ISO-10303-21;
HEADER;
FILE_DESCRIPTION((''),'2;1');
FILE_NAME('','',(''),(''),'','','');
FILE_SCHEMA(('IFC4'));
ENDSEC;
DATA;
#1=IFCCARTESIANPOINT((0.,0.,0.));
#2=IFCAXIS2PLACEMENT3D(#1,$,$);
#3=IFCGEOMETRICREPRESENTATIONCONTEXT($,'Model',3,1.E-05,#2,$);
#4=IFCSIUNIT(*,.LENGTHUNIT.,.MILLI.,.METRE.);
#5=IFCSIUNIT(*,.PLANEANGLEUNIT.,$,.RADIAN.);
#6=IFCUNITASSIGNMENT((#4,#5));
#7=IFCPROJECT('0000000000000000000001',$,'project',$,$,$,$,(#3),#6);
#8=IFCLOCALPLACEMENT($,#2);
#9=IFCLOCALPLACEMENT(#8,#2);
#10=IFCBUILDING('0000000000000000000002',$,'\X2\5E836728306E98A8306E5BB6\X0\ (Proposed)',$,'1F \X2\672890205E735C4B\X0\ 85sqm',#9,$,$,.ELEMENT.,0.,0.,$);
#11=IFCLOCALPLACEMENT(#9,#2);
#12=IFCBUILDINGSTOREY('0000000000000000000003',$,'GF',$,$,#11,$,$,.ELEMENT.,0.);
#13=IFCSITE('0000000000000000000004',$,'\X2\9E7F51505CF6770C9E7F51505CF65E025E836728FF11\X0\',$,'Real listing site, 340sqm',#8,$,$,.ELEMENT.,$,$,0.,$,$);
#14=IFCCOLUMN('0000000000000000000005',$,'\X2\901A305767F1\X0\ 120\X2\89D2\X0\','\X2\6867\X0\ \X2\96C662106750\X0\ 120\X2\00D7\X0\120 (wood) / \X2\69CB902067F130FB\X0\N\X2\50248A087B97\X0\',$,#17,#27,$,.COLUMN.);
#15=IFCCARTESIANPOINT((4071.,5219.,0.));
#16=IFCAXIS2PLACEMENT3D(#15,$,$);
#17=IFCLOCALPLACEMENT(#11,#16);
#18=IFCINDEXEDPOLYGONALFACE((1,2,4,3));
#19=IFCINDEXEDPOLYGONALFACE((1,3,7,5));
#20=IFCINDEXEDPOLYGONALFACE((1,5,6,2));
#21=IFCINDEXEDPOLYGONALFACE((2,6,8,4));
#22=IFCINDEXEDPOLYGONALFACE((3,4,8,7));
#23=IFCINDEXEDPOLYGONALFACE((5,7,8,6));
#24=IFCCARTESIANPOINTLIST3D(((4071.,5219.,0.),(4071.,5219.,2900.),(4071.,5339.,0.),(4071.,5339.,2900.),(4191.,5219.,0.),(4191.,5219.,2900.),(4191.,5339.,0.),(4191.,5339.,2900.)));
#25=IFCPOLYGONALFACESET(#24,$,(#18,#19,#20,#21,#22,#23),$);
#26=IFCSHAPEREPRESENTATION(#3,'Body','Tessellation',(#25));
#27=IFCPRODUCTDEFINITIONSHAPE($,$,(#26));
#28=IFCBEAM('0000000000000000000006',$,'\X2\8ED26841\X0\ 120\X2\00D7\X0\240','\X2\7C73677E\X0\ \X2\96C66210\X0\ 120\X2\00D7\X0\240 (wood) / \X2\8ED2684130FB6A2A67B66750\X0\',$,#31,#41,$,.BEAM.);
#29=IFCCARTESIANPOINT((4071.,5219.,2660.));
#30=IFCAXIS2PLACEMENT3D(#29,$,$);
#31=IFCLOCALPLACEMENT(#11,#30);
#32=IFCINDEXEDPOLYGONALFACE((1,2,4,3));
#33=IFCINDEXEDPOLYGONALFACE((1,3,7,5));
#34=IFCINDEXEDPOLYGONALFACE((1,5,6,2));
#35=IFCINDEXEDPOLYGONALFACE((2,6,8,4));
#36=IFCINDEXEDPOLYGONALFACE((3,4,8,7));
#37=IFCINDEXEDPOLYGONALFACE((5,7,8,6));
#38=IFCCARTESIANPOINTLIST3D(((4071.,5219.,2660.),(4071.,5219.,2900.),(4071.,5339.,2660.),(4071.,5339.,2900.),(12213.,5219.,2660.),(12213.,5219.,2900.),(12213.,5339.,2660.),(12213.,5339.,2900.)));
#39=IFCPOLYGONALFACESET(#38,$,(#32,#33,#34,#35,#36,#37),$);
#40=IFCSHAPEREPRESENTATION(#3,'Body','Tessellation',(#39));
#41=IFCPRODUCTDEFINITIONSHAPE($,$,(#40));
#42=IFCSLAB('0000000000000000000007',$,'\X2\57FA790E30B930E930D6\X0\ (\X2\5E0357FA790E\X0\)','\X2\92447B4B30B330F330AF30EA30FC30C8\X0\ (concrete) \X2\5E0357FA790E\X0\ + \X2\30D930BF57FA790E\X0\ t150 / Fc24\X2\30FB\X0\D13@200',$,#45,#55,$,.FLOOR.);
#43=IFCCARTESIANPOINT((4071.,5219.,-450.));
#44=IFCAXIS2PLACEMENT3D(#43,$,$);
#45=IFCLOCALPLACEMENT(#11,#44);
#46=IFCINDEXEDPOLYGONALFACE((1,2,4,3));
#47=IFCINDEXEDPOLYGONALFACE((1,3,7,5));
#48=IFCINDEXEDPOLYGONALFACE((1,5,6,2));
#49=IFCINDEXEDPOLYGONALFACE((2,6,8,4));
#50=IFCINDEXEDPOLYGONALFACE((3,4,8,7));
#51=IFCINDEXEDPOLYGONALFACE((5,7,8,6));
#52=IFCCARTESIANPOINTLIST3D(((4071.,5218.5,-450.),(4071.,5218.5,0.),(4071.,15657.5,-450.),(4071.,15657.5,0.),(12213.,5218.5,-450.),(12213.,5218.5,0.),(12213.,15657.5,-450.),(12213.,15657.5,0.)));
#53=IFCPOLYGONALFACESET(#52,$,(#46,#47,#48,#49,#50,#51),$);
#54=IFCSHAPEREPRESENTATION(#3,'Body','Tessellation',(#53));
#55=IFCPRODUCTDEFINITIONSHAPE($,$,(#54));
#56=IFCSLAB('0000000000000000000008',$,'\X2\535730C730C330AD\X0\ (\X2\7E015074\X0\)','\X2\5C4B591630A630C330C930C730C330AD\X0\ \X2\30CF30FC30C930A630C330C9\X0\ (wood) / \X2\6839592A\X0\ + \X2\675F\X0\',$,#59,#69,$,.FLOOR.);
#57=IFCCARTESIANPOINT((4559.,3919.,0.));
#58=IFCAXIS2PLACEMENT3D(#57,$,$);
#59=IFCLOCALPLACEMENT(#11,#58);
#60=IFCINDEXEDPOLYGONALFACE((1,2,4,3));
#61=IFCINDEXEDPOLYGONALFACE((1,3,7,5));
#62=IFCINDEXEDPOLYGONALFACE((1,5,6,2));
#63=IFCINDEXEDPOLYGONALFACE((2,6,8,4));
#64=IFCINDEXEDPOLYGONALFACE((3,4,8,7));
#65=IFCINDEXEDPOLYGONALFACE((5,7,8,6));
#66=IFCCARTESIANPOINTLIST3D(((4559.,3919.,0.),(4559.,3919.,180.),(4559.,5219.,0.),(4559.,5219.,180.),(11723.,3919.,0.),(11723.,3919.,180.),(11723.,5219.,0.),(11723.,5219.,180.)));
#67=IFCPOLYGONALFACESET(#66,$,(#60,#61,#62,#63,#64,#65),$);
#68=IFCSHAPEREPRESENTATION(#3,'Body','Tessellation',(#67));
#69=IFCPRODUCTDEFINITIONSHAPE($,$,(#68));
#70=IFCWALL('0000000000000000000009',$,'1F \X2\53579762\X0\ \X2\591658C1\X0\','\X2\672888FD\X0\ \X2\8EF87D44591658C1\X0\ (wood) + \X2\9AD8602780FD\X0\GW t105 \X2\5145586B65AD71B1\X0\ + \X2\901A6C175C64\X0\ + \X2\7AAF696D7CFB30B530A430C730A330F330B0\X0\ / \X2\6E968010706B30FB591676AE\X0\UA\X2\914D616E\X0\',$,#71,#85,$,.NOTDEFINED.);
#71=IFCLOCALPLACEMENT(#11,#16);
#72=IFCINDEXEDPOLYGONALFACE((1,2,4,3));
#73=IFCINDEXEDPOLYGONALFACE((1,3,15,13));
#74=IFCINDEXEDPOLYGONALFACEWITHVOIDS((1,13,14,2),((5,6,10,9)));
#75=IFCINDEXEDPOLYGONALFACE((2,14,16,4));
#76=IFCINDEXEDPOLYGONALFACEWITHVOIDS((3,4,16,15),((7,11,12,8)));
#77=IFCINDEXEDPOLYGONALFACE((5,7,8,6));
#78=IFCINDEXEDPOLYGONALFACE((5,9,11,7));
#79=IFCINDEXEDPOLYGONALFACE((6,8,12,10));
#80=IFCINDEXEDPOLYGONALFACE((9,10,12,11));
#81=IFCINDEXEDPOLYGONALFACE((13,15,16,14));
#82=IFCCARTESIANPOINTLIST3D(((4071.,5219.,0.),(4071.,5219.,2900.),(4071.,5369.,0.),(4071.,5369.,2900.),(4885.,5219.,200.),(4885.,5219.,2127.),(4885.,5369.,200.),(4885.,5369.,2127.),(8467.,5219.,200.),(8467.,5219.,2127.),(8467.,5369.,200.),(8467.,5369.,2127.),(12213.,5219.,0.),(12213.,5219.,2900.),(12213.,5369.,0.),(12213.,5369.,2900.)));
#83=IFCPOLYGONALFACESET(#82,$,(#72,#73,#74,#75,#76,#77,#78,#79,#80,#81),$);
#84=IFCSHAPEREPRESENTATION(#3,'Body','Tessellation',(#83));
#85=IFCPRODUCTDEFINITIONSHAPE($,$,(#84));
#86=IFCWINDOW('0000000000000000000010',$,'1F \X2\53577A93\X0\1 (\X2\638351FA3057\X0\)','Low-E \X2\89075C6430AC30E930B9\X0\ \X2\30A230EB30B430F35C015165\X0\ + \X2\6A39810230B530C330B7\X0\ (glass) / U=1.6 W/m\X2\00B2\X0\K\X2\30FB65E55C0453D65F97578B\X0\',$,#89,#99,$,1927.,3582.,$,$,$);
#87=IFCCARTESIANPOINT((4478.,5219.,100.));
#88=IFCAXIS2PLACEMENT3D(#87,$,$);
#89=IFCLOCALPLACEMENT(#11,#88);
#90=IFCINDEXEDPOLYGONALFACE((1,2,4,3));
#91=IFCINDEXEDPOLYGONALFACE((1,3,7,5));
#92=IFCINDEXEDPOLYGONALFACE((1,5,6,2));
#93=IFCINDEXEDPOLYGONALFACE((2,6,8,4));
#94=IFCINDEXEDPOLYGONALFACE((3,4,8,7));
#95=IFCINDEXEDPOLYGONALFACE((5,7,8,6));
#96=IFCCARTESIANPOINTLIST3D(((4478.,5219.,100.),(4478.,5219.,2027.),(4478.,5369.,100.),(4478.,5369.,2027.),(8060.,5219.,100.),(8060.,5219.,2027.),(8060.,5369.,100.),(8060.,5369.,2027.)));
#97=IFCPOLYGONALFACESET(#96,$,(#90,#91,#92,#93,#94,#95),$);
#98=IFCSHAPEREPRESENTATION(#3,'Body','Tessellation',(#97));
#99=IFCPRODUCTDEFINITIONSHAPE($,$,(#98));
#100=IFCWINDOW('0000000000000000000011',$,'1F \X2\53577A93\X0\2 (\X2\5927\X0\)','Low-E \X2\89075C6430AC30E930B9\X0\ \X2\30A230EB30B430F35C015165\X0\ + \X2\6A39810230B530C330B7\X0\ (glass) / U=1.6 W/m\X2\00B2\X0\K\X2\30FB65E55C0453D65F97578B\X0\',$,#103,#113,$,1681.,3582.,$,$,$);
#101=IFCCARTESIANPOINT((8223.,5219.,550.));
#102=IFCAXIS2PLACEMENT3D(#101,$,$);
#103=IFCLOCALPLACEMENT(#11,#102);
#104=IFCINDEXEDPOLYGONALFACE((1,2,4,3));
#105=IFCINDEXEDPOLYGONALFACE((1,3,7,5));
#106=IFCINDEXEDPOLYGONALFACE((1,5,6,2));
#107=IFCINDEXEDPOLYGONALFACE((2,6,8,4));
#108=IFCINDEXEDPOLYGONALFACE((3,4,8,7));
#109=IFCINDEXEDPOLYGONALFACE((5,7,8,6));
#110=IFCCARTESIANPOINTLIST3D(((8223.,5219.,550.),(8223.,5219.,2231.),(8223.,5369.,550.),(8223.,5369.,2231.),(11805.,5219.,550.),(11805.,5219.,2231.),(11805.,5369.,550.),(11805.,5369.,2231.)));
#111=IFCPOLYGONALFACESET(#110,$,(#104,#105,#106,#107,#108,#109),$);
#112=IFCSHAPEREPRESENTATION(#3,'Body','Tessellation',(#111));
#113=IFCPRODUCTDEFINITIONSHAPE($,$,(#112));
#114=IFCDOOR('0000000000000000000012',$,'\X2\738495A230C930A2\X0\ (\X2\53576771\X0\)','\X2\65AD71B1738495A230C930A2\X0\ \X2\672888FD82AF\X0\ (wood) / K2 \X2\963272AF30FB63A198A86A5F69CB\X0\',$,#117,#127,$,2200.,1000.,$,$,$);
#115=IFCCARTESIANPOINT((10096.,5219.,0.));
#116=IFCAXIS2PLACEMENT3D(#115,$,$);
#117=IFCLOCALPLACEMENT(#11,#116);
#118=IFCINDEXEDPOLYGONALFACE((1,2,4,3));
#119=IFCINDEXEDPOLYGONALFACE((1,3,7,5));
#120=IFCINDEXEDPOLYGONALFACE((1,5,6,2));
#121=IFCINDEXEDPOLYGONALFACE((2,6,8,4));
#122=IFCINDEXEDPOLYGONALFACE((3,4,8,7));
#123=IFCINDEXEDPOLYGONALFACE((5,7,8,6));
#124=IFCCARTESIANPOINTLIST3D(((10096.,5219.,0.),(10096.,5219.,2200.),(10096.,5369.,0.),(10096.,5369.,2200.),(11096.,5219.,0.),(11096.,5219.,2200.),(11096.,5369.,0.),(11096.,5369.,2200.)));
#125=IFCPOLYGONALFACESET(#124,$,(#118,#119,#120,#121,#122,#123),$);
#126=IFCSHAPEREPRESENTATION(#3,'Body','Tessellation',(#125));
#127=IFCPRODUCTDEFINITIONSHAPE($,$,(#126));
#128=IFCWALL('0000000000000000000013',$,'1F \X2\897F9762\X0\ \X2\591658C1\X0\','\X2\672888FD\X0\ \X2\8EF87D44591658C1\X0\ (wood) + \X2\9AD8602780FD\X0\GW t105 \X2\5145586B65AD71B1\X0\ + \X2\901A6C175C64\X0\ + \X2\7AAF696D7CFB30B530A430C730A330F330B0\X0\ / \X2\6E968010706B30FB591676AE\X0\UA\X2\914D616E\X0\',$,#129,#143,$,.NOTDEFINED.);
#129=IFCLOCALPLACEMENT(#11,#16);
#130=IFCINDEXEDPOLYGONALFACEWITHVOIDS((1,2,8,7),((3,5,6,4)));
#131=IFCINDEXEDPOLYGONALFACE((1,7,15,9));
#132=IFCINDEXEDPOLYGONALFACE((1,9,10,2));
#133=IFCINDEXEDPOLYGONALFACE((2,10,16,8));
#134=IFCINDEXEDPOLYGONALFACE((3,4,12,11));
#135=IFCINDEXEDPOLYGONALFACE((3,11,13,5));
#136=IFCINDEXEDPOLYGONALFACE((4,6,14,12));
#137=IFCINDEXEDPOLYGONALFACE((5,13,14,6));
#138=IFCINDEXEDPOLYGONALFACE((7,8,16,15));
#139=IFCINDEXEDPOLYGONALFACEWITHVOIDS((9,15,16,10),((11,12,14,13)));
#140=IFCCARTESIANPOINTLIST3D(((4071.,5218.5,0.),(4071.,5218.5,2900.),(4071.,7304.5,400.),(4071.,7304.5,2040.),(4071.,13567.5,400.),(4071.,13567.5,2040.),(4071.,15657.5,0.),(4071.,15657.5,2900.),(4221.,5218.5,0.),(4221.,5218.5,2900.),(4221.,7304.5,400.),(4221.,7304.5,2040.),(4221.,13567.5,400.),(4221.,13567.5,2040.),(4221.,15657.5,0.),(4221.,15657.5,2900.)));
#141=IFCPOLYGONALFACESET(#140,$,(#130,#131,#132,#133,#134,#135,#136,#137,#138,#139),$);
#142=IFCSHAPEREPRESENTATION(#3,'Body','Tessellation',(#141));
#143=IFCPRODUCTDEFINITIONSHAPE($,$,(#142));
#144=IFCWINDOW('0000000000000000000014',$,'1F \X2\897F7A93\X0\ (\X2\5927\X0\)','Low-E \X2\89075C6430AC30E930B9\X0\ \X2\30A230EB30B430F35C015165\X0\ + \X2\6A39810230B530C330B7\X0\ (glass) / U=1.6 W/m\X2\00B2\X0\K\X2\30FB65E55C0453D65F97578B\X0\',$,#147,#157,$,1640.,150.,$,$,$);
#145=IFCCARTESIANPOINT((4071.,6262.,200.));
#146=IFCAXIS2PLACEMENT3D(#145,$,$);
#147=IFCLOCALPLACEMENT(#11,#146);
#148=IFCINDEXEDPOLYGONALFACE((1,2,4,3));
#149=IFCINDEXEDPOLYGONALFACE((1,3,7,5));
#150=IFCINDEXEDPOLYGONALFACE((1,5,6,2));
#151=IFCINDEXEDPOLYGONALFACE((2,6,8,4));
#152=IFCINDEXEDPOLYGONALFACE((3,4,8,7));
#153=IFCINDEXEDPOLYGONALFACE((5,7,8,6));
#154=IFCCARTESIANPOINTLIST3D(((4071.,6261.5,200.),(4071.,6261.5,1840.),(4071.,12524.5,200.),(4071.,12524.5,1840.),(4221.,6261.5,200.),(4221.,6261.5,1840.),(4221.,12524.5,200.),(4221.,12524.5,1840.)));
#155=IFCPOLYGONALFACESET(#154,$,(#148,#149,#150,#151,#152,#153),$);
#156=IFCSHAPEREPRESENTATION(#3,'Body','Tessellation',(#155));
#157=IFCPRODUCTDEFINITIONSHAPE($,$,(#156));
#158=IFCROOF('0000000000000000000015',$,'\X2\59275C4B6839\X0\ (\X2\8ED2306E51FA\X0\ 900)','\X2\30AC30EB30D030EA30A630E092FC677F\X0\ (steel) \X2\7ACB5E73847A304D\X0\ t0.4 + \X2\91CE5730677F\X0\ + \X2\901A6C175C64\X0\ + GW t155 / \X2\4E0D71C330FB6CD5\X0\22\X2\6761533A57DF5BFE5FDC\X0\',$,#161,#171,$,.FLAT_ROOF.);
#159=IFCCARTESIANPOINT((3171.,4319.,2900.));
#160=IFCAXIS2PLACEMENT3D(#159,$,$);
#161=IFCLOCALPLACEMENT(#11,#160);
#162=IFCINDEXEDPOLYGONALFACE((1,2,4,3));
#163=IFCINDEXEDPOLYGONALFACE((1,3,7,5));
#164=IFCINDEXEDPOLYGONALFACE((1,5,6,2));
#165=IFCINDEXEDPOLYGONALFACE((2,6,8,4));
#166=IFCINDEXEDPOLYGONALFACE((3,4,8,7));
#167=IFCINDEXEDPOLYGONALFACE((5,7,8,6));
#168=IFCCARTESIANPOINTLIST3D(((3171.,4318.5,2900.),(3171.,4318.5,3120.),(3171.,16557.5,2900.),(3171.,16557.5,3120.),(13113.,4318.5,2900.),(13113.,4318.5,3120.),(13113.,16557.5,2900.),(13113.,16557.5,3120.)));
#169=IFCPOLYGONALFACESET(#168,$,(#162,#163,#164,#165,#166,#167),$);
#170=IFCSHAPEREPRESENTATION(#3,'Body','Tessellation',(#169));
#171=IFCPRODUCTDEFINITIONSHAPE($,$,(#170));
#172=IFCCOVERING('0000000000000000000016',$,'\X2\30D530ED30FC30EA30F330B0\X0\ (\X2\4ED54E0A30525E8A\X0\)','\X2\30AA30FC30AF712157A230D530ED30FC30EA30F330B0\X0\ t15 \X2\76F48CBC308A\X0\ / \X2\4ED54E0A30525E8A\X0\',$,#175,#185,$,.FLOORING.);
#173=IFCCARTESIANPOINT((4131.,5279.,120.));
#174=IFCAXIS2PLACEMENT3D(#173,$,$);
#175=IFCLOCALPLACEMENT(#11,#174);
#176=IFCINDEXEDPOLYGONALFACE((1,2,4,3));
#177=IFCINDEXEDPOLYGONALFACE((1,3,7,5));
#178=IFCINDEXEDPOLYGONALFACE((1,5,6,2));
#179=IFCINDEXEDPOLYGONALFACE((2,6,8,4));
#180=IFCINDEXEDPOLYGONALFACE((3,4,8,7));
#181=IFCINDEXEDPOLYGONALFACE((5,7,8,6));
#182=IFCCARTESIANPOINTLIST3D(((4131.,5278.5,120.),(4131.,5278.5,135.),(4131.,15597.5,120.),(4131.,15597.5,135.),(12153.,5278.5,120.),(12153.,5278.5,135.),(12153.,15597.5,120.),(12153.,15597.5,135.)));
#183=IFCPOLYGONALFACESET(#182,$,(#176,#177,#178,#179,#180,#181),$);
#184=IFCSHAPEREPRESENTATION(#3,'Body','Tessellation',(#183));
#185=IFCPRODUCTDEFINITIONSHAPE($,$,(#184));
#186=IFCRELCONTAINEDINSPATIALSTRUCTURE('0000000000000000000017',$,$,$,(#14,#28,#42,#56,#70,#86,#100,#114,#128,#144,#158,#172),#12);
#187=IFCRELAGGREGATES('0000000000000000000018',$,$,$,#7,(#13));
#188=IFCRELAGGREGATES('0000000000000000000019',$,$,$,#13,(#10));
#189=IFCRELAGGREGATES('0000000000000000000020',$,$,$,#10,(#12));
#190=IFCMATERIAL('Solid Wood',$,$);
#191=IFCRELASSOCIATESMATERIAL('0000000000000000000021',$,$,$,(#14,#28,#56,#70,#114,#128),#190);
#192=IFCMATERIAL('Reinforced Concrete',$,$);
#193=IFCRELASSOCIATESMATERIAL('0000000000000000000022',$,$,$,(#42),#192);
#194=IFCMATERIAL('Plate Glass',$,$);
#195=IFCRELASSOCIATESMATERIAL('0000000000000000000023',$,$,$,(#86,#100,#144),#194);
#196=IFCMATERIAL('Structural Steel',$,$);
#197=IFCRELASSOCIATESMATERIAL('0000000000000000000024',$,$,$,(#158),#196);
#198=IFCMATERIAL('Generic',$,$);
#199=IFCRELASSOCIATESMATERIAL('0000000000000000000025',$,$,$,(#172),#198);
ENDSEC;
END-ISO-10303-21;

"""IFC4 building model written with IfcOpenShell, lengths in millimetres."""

from ifc_helpers import new_model, si_unit, frame, frame_2d, origin, place, context, project, spatial, rectangle, extrude, material, element, fill, save


model = new_model("IFC4")

# Units and contexts
model_context = context("Model", 3, precision=1e-05, world=origin())
ifc_project = project(units=[si_unit("LENGTHUNIT", "METRE", prefix="MILLI"), si_unit("PLANEANGLEUNIT", "RADIAN")], contexts=[model_context])

# Site, building, storey
site_placement = place(None, origin())
site = spatial("IfcSite", under=ifc_project, at=site_placement, Name="鹿児島県鹿児島市広木１", ObjectType="Real listing site, 340sqm", CompositionType="ELEMENT", RefElevation=0.0)
building_placement = place(site_placement, origin())
building = spatial("IfcBuilding", under=site, at=building_placement, Name="広木の風の家 (Proposed)", ObjectType="1F 木造平屋 85sqm", CompositionType="ELEMENT", ElevationOfRefHeight=0.0, ElevationOfTerrain=0.0)
storey_placement = place(building_placement, origin())
storey = spatial("IfcBuildingStorey", under=building, at=storey_placement, Name="GF", CompositionType="ELEMENT", Elevation=0.0)

# Column
ifc_material_1 = material(Name="Solid Wood")
column_1_placement = place(storey_placement, frame((4071.0, 5219.0, 0.0)))
element("IfcColumn", 1, at=column_1_placement, inside=storey, material=ifc_material_1, Name="通し柱 120角", Description="桧 集成材 120×120 (wood) / 構造柱・N値計算", PredefinedType="COLUMN", context=model_context, shape_type="SweptSolid", body=[
    extrude(rectangle(XDim=120.0, YDim=120.0, at=frame_2d((60.0, 60.0))), frame((4071.0, 5219.0, 0.0)), (0.0, 0.0, 1.0), 2900.0),
])

# Beam
beam_1_placement = place(storey_placement, frame((4071.0, 5219.0, 2660.0)))
element("IfcBeam", 2, at=beam_1_placement, inside=storey, material=ifc_material_1, Name="軒桁 120×240", Description="米松 集成 120×240 (wood) / 軒桁・横架材", PredefinedType="BEAM", context=model_context, shape_type="SweptSolid", body=[
    extrude(rectangle(XDim=8142.0, YDim=120.0, at=frame_2d((4071.0, 60.0))), frame((4071.0, 5219.0, 2660.0)), (0.0, 0.0, 1.0), 240.0),
])

# Slabs
ifc_material_2 = material(Name="Reinforced Concrete")
slab_1_placement = place(storey_placement, frame((4071.0, 5219.0, -450.0)))
element("IfcSlab", 3, at=slab_1_placement, inside=storey, material=ifc_material_2, Name="基礎スラブ (布基礎)", Description="鉄筋コンクリート (concrete) 布基礎 + ベタ基礎 t150 / Fc24・D13@200", PredefinedType="FLOOR", context=model_context, shape_type="SweptSolid", body=[
    extrude(rectangle(XDim=8142.0, YDim=10439.0, at=frame_2d((4071.0, 5219.0))), frame((4071.0, 5219.0, -450.0)), (0.0, 0.0, 1.0), 450.0),
])
slab_2_placement = place(storey_placement, frame((4559.0, 3919.0, 0.0)))
element("IfcSlab", 4, at=slab_2_placement, inside=storey, material=ifc_material_1, Name="南デッキ (縁側)", Description="屋外ウッドデッキ ハードウッド (wood) / 根太 + 束", PredefinedType="FLOOR", context=model_context, shape_type="SweptSolid", body=[
    extrude(rectangle(XDim=7164.0, YDim=1300.0, at=frame_2d((3582.0, 650.0))), frame((4559.0, 3919.0, 0.0)), (0.0, 0.0, 1.0), 180.0),
])

# Wall, openings, windows, door
wall_1_placement = place(storey_placement, frame((4071.0, 5219.0, 0.0)))
wall_1 = element("IfcWall", 5, at=wall_1_placement, inside=storey, material=ifc_material_1, Name="1F 南面 外壁", Description="木製 軸組外壁 (wood) + 高性能GW t105 充填断熱 + 通気層 + 窯業系サイディング / 準耐火・外皮UA配慮", PredefinedType="NOTDEFINED", context=model_context, shape_type="SweptSolid", body=[
    extrude(rectangle(XDim=8142.0, YDim=150.0, at=frame_2d((4071.0, 75.0))), frame((4071.0, 5219.0, 0.0)), (0.0, 0.0, 1.0), 2900.0),
])
opening_1_placement = place(storey_placement, frame((4478.0, 5219.0, 100.0)))
opening_1 = element("IfcOpeningElement", 6, at=opening_1_placement, cuts=wall_1, PredefinedType="NOTDEFINED", context=model_context, shape_type="SweptSolid", body=[
    extrude(rectangle(XDim=3582.0, YDim=150.0, at=frame_2d((1791.0, 75.0))), frame((4478.0, 5219.0, 100.0)), (0.0, 0.0, 1.0), 1927.0),
])
opening_2_placement = place(storey_placement, frame((8223.0, 5219.0, 550.0)))
opening_2 = element("IfcOpeningElement", 7, at=opening_2_placement, cuts=wall_1, PredefinedType="NOTDEFINED", context=model_context, shape_type="SweptSolid", body=[
    extrude(rectangle(XDim=3582.0, YDim=150.0, at=frame_2d((1791.0, 75.0))), frame((8223.0, 5219.0, 550.0)), (0.0, 0.0, 1.0), 1681.0),
])
opening_3_placement = place(storey_placement, frame((10096.0, 5219.0, 0.0)))
opening_3 = element("IfcOpeningElement", 8, at=opening_3_placement, cuts=wall_1, PredefinedType="NOTDEFINED", context=model_context, shape_type="SweptSolid", body=[
    extrude(rectangle(XDim=1000.0, YDim=150.0, at=frame_2d((500.0, 75.0))), frame((10096.0, 5219.0, 0.0)), (0.0, 0.0, 1.0), 2200.0),
])
ifc_material_3 = material(Name="Plate Glass")
window_1_placement = place(storey_placement, frame((4478.0, 5219.0, 100.0)))
window_1 = element("IfcWindow", 9, at=window_1_placement, inside=storey, material=ifc_material_3, Name="1F 南窓1 (掃出し)", Description="Low-E 複層ガラス アルゴン封入 + 樹脂サッシ (glass) / U=1.6 W/m²K・日射取得型", OverallHeight=1927.0, OverallWidth=3582.0, context=model_context, shape_type="SweptSolid", body=[
    extrude(rectangle(XDim=3582.0, YDim=150.0, at=frame_2d((1791.0, 75.0))), frame((4478.0, 5219.0, 100.0)), (0.0, 0.0, 1.0), 1927.0),
])
fill(opening_1, window_1)
window_2_placement = place(storey_placement, frame((8223.0, 5219.0, 550.0)))
window_2 = element("IfcWindow", 10, at=window_2_placement, inside=storey, material=ifc_material_3, Name="1F 南窓2 (大)", Description="Low-E 複層ガラス アルゴン封入 + 樹脂サッシ (glass) / U=1.6 W/m²K・日射取得型", OverallHeight=1681.0, OverallWidth=3582.0, context=model_context, shape_type="SweptSolid", body=[
    extrude(rectangle(XDim=3582.0, YDim=150.0, at=frame_2d((1791.0, 75.0))), frame((8223.0, 5219.0, 550.0)), (0.0, 0.0, 1.0), 1681.0),
])
fill(opening_2, window_2)
door_placement = place(storey_placement, frame((10096.0, 5219.0, 0.0)))
door = element("IfcDoor", 11, at=door_placement, inside=storey, material=ifc_material_1, Name="玄関ドア (南東)", Description="断熱玄関ドア 木製芯 (wood) / K2 防犯・採風機構", OverallHeight=2200.0, OverallWidth=1000.0, context=model_context, shape_type="SweptSolid", body=[
    extrude(rectangle(XDim=1000.0, YDim=150.0, at=frame_2d((500.0, 75.0))), frame((10096.0, 5219.0, 0.0)), (0.0, 0.0, 1.0), 2200.0),
])
fill(opening_3, door)

# Wall, opening, window
wall_2_placement = place(storey_placement, frame((4071.0, 5219.0, 0.0)))
wall_2 = element("IfcWall", 12, at=wall_2_placement, inside=storey, material=ifc_material_1, Name="1F 西面 外壁", Description="木製 軸組外壁 (wood) + 高性能GW t105 充填断熱 + 通気層 + 窯業系サイディング / 準耐火・外皮UA配慮", PredefinedType="NOTDEFINED", context=model_context, shape_type="SweptSolid", body=[
    extrude(rectangle(XDim=150.0, YDim=10439.0, at=frame_2d((75.0, 5219.0))), frame((4071.0, 5219.0, 0.0)), (0.0, 0.0, 1.0), 2900.0),
])
opening_4_placement = place(storey_placement, frame((4071.0, 6262.0, 200.0)))
opening_4 = element("IfcOpeningElement", 13, at=opening_4_placement, cuts=wall_2, PredefinedType="NOTDEFINED", context=model_context, shape_type="SweptSolid", body=[
    extrude(rectangle(XDim=150.0, YDim=6263.0, at=frame_2d((75.0, 3131.0))), frame((4071.0, 6262.0, 200.0)), (0.0, 0.0, 1.0), 1640.0),
])
window_3_placement = place(storey_placement, frame((4071.0, 6262.0, 200.0)))
window_3 = element("IfcWindow", 14, at=window_3_placement, inside=storey, material=ifc_material_3, Name="1F 西窓 (大)", Description="Low-E 複層ガラス アルゴン封入 + 樹脂サッシ (glass) / U=1.6 W/m²K・日射取得型", OverallHeight=1640.0, OverallWidth=150.0, context=model_context, shape_type="SweptSolid", body=[
    extrude(rectangle(XDim=150.0, YDim=6263.0, at=frame_2d((75.0, 3131.0))), frame((4071.0, 6262.0, 200.0)), (0.0, 0.0, 1.0), 1640.0),
])
fill(opening_4, window_3)

# Roof
ifc_material_4 = material(Name="Structural Steel")
roof_placement = place(storey_placement, frame((3171.0, 4319.0, 2900.0)))
element("IfcRoof", 15, at=roof_placement, inside=storey, material=ifc_material_4, Name="大屋根 (軒の出 900)", Description="ガルバリウム鋼板 (steel) 立平葺き t0.4 + 野地板 + 通気層 + GW t155 / 不燃・法22条区域対応", PredefinedType="FLAT_ROOF", context=model_context, shape_type="SweptSolid", body=[
    extrude(rectangle(XDim=9942.0, YDim=12239.0, at=frame_2d((4971.0, 6119.0))), frame((3171.0, 4319.0, 2900.0)), (0.0, 0.0, 1.0), 220.0),
])

# Covering
ifc_material_5 = material(Name="Generic")
covering_1_placement = place(storey_placement, frame((4131.0, 5279.0, 120.0)))
element("IfcCovering", 16, at=covering_1_placement, inside=storey, material=ifc_material_5, Name="フローリング (仕上げ床)", Description="オーク無垢フローリング t15 直貼り / 仕上げ床", PredefinedType="FLOORING", context=model_context, shape_type="SweptSolid", body=[
    extrude(rectangle(XDim=8022.0, YDim=10319.0, at=frame_2d((4011.0, 5159.0))), frame((4131.0, 5279.0, 120.0)), (0.0, 0.0, 1.0), 15.0),
])

save(model, "model.ifc")
